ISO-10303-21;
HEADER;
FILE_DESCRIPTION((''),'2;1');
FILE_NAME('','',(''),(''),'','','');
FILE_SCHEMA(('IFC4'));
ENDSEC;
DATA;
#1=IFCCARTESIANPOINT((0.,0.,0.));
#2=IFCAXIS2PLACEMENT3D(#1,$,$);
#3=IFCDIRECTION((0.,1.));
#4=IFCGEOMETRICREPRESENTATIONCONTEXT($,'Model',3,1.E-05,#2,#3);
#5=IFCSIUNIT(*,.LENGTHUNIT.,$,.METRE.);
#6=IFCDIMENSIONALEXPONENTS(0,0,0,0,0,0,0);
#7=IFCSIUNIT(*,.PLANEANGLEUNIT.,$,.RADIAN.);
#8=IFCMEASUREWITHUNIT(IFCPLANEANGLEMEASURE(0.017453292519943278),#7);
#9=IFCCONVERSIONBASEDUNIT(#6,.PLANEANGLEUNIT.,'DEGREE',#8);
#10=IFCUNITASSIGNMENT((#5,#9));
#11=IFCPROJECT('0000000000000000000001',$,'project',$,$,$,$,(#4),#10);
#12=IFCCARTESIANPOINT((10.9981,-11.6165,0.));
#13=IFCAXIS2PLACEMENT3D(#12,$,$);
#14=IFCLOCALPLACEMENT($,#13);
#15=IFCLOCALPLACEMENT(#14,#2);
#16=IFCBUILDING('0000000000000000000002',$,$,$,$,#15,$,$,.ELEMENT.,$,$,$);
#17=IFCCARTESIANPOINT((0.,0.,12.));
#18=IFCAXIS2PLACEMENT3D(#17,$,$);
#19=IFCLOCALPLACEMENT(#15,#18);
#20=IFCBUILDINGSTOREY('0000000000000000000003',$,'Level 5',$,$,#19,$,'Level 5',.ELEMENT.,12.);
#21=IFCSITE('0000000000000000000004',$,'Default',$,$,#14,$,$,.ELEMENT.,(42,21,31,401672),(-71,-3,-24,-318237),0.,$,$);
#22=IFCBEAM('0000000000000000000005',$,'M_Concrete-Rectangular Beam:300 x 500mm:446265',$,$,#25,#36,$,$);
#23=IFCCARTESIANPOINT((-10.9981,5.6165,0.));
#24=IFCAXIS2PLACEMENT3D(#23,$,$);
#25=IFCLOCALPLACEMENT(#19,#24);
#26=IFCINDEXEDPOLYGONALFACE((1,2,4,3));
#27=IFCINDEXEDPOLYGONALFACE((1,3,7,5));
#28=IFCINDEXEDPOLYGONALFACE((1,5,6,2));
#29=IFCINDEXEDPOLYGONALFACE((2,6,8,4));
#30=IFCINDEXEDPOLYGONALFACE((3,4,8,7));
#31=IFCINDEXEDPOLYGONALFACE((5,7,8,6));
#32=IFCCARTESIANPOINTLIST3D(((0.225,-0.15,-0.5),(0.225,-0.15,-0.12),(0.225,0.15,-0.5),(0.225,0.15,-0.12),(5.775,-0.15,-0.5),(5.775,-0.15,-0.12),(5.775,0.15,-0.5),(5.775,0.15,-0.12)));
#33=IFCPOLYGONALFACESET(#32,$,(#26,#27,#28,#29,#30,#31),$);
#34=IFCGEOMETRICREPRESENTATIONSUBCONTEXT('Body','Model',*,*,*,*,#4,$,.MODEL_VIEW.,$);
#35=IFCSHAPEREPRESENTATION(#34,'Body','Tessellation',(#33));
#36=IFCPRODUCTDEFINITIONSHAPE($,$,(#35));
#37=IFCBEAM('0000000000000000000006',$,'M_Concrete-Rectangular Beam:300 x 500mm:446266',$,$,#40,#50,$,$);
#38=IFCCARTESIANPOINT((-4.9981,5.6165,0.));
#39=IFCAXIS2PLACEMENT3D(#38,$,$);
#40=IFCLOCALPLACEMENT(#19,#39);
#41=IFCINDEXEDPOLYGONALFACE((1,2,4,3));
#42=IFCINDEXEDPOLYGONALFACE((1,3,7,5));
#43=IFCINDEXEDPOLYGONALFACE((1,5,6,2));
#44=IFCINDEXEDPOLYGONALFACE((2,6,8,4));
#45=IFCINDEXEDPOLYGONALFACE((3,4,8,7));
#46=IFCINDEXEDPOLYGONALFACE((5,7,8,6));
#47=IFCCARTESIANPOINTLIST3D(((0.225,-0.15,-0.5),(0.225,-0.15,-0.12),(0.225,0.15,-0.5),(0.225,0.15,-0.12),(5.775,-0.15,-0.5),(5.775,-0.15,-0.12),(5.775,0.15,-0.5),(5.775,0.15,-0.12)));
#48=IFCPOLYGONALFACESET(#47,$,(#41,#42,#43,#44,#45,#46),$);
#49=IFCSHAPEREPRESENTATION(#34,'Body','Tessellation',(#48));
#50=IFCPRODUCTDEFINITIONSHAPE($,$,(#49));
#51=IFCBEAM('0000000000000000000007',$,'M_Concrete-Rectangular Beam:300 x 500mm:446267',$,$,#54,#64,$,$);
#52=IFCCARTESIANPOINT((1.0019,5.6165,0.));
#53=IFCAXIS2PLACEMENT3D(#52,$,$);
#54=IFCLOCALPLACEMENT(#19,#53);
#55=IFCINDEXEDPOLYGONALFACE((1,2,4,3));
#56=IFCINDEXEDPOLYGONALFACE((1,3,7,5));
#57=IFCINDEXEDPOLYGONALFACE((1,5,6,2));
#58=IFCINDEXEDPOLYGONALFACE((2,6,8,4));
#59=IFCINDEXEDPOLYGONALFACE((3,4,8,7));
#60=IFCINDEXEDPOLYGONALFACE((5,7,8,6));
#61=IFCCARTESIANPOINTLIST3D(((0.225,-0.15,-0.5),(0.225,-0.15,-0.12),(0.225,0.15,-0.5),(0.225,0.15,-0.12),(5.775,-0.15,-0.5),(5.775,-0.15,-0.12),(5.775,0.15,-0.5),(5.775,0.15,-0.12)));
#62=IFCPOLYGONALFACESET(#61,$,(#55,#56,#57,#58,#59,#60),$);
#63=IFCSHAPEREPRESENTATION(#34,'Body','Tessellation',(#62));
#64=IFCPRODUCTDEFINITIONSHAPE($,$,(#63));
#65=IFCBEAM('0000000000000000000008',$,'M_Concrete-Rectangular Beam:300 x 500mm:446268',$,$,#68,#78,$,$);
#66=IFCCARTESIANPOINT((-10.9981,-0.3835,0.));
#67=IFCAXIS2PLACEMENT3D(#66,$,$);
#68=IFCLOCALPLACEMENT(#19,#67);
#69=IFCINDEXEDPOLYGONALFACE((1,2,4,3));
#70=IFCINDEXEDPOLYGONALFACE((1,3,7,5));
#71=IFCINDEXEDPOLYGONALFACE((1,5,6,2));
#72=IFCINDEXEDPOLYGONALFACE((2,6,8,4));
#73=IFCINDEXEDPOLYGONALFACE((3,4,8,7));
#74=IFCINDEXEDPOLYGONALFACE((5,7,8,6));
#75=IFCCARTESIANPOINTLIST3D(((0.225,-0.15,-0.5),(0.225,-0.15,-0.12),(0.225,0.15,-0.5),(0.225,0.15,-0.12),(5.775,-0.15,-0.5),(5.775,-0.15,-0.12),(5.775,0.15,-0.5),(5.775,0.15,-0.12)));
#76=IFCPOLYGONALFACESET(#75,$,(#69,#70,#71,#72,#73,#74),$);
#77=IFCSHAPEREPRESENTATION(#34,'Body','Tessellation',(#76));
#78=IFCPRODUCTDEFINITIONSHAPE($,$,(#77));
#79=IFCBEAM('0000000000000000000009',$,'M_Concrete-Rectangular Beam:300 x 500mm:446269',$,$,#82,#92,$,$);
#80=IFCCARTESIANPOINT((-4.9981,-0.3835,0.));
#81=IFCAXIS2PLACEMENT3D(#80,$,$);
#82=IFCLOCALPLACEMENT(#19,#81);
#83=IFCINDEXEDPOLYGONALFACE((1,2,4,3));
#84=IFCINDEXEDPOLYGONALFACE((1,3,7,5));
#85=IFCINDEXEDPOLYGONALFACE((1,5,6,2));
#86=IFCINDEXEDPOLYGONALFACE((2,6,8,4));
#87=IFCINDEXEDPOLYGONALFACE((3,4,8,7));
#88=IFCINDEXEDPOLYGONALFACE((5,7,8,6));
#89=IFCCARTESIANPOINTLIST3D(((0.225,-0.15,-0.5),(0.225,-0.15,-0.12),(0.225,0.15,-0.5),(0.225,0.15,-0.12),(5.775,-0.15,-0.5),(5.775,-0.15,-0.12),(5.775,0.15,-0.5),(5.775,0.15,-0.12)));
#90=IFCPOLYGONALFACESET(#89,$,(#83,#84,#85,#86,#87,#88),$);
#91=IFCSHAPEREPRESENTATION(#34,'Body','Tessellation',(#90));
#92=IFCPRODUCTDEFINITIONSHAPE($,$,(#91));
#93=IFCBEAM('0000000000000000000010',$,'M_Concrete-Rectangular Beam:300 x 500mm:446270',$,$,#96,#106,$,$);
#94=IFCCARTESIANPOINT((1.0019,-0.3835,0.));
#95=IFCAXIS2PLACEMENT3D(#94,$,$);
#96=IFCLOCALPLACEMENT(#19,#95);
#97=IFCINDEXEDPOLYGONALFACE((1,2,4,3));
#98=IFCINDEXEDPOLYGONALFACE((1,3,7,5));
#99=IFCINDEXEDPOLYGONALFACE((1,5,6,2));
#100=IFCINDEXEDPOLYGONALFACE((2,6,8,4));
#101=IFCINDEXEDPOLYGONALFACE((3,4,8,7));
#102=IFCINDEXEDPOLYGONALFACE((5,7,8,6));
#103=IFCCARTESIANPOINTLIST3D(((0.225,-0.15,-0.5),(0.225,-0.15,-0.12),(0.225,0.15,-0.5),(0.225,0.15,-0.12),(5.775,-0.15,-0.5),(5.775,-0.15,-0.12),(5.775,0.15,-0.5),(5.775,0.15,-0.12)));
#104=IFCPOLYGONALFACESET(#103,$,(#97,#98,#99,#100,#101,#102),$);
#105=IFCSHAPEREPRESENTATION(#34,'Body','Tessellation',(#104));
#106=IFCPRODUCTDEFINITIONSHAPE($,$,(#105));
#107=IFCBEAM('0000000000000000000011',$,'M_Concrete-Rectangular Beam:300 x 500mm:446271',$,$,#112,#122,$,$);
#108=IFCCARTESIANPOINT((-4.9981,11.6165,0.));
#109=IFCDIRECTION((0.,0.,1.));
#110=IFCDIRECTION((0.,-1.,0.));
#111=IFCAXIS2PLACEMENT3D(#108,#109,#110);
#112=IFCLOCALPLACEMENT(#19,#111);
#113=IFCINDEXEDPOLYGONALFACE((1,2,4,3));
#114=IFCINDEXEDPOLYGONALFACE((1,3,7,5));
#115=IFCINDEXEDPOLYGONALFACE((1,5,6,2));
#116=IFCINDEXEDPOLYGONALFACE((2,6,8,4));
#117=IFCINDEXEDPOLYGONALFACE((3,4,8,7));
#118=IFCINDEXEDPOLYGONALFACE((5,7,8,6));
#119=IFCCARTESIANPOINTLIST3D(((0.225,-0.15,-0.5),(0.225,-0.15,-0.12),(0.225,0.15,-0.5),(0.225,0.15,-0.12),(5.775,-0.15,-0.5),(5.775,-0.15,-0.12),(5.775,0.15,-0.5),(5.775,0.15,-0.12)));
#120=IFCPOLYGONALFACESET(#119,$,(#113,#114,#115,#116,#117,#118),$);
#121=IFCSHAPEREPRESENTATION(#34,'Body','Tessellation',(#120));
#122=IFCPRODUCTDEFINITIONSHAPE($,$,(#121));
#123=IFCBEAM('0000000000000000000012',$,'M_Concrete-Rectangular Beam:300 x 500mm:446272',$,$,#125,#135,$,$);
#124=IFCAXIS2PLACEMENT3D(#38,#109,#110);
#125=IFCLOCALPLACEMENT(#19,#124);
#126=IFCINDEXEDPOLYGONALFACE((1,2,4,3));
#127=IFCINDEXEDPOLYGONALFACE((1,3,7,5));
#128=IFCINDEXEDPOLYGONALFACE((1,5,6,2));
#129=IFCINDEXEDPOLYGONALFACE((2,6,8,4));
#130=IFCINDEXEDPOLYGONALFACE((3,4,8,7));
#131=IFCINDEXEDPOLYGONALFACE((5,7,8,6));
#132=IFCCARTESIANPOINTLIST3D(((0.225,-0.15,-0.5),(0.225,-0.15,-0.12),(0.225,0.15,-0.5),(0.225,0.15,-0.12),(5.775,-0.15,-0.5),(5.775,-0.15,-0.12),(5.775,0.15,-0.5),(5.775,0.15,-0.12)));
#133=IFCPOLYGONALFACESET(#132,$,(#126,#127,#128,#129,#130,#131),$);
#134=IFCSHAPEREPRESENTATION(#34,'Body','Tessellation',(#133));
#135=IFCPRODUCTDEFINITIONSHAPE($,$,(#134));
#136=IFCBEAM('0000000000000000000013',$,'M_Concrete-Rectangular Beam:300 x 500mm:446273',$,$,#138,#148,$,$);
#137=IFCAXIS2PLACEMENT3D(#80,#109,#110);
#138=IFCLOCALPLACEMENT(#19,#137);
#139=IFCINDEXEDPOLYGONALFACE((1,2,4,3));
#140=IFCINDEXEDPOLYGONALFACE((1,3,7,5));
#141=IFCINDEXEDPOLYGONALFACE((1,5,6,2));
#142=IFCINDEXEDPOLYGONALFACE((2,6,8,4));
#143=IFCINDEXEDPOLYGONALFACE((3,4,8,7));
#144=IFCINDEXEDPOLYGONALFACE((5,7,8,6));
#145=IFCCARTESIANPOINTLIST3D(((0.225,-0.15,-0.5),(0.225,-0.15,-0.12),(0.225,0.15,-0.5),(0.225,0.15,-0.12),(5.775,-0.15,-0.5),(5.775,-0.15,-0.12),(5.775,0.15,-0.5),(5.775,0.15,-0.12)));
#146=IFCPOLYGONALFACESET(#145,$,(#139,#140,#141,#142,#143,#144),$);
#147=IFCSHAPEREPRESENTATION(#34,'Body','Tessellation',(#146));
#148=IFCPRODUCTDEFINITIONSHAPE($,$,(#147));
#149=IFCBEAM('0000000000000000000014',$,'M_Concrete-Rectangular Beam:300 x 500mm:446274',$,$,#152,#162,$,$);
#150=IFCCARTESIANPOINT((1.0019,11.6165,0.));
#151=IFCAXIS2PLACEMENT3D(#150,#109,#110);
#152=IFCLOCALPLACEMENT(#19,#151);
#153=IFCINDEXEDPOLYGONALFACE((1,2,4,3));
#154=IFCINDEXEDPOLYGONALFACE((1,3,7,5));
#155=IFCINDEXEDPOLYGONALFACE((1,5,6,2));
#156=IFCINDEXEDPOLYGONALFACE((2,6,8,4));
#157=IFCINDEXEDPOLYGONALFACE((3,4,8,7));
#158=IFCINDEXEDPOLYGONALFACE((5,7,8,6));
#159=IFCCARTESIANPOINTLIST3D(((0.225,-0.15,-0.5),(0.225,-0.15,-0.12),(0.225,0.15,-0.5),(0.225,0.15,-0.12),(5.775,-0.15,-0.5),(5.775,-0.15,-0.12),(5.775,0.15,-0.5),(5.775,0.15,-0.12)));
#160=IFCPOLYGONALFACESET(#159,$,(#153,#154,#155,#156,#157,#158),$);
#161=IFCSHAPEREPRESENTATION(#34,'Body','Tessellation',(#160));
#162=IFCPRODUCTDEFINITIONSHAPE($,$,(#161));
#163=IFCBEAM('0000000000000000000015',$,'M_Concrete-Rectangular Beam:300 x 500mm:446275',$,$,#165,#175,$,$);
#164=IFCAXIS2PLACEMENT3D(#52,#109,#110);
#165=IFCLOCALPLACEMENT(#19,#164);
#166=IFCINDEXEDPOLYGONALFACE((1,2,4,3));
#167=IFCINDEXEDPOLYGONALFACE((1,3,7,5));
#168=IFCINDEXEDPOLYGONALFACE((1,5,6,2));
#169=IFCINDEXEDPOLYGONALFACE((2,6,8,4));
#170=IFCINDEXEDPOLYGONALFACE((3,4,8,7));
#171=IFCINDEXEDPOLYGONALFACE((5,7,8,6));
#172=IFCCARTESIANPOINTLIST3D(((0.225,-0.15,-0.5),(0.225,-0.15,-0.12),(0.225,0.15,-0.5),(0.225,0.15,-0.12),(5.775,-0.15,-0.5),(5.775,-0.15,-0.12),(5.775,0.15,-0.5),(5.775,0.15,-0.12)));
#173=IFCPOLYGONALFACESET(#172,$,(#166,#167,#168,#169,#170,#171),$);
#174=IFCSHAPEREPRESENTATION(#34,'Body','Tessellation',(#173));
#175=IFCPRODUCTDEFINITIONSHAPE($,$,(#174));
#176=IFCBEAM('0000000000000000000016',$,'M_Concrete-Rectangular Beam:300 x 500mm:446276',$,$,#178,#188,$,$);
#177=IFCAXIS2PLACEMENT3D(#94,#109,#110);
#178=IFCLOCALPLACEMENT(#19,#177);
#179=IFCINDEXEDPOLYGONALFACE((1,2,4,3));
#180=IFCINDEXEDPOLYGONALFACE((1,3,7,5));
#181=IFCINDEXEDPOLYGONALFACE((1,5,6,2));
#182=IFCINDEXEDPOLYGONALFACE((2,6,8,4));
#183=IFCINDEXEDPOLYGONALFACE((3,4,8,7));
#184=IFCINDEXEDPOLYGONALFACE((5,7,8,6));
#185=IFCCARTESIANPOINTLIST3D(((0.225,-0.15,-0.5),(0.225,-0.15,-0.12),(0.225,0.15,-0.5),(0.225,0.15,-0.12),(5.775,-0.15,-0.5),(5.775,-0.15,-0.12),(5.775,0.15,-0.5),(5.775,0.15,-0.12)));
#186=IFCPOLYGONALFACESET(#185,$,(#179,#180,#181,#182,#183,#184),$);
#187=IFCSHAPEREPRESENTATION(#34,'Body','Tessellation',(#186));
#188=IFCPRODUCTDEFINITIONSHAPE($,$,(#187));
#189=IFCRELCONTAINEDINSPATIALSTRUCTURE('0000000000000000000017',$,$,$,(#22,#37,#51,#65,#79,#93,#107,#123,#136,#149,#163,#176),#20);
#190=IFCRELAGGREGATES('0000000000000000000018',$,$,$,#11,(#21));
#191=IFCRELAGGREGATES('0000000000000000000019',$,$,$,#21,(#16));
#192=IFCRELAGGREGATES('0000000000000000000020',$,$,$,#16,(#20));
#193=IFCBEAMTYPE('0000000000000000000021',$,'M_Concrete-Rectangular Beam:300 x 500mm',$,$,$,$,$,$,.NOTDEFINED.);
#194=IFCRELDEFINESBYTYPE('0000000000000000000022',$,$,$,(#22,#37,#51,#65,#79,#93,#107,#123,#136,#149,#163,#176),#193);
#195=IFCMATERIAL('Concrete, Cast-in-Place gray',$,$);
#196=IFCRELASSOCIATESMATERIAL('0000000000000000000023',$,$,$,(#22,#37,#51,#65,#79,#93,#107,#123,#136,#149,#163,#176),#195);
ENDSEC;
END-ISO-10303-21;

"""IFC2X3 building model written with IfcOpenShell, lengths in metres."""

from ifc_helpers import new_model, entity, si_unit, converted_unit, direction, frame, frame_2d, origin, place, context, subcontext, project, spatial, rectangle, extrude, material, type_object, element, save


model = new_model("IFC2X3")

# Units and contexts
model_context = context("Model", 3, precision=1e-05, world=origin(), true_north=direction((0.0, 1.0)))
body_context = subcontext(model_context, "Body", "Model", "MODEL_VIEW")
ifc_project = project(units=[si_unit("LENGTHUNIT", "METRE"), converted_unit("PLANEANGLEUNIT", "DEGREE", entity("IfcPlaneAngleMeasure", 0.017453292519943278), si_unit("PLANEANGLEUNIT", "RADIAN"), dimensions=[0, 0, 0, 0, 0, 0, 0])], contexts=[model_context])

# Site, building, storey
site_placement = place(None, frame((10.9981, -11.6165, 0.0)))
site = spatial("IfcSite", under=ifc_project, at=site_placement, Name="Default", CompositionType="ELEMENT", RefLatitude=(42, 21, 31, 401672), RefLongitude=(-71, -3, -24, -318237), RefElevation=0.0)
building_placement = place(site_placement, origin())
building = spatial("IfcBuilding", under=site, at=building_placement, CompositionType="ELEMENT")
storey_placement = place(building_placement, frame((0.0, 0.0, 12.0)))
storey = spatial("IfcBuildingStorey", under=building, at=storey_placement, Name="Level 5", LongName="Level 5", CompositionType="ELEMENT", Elevation=12.0)

# Beams
ifc_material_1 = material(Name="Concrete, Cast-in-Place gray")
beam_type = type_object("IfcBeamType", Name="M_Concrete-Rectangular Beam:300 x 500mm", PredefinedType="NOTDEFINED")
beam_1_placement = place(storey_placement, frame((-10.9981, 5.6165, 0.0)))
element("IfcBeam", 1, at=beam_1_placement, inside=storey, type_object=beam_type, material=ifc_material_1, Name="M_Concrete-Rectangular Beam:300 x 500mm:446265", context=body_context, shape_type="SweptSolid", body=[
    extrude(rectangle(XDim=0.38, YDim=0.3, at=frame_2d((0.0, 0.0), x_axis=(1.0, 0.0))), frame((0.225, 0.0, -0.31), z_axis=(1.0, 0.0, 0.0), x_axis=(0.0, 0.0, -1.0)), (0.0, 0.0, 1.0), 5.55),
])
beam_2_placement = place(storey_placement, frame((-4.9981, 5.6165, 0.0)))
element("IfcBeam", 2, at=beam_2_placement, inside=storey, type_object=beam_type, material=ifc_material_1, Name="M_Concrete-Rectangular Beam:300 x 500mm:446266", context=body_context, shape_type="SweptSolid", body=[
    extrude(rectangle(XDim=0.38, YDim=0.3, at=frame_2d((0.0, 0.0), x_axis=(1.0, 0.0))), frame((0.225, 0.0, -0.31), z_axis=(1.0, 0.0, 0.0), x_axis=(0.0, 0.0, -1.0)), (0.0, 0.0, 1.0), 5.55),
])
beam_3_placement = place(storey_placement, frame((1.0019, 5.6165, 0.0)))
element("IfcBeam", 3, at=beam_3_placement, inside=storey, type_object=beam_type, material=ifc_material_1, Name="M_Concrete-Rectangular Beam:300 x 500mm:446267", context=body_context, shape_type="SweptSolid", body=[
    extrude(rectangle(XDim=0.38, YDim=0.3, at=frame_2d((0.0, 0.0), x_axis=(1.0, 0.0))), frame((0.225, 0.0, -0.31), z_axis=(1.0, 0.0, 0.0), x_axis=(0.0, 0.0, -1.0)), (0.0, 0.0, 1.0), 5.55),
])
beam_4_placement = place(storey_placement, frame((-10.9981, -0.3835, 0.0)))
element("IfcBeam", 4, at=beam_4_placement, inside=storey, type_object=beam_type, material=ifc_material_1, Name="M_Concrete-Rectangular Beam:300 x 500mm:446268", context=body_context, shape_type="SweptSolid", body=[
    extrude(rectangle(XDim=0.38, YDim=0.3, at=frame_2d((0.0, 0.0), x_axis=(1.0, 0.0))), frame((0.225, 0.0, -0.31), z_axis=(1.0, 0.0, 0.0), x_axis=(0.0, 0.0, -1.0)), (0.0, 0.0, 1.0), 5.55),
])
beam_5_placement = place(storey_placement, frame((-4.9981, -0.3835, 0.0)))
element("IfcBeam", 5, at=beam_5_placement, inside=storey, type_object=beam_type, material=ifc_material_1, Name="M_Concrete-Rectangular Beam:300 x 500mm:446269", context=body_context, shape_type="SweptSolid", body=[
    extrude(rectangle(XDim=0.38, YDim=0.3, at=frame_2d((0.0, 0.0), x_axis=(1.0, 0.0))), frame((0.225, 0.0, -0.31), z_axis=(1.0, 0.0, 0.0), x_axis=(0.0, 0.0, -1.0)), (0.0, 0.0, 1.0), 5.55),
])
beam_6_placement = place(storey_placement, frame((1.0019, -0.3835, 0.0)))
element("IfcBeam", 6, at=beam_6_placement, inside=storey, type_object=beam_type, material=ifc_material_1, Name="M_Concrete-Rectangular Beam:300 x 500mm:446270", context=body_context, shape_type="SweptSolid", body=[
    extrude(rectangle(XDim=0.38, YDim=0.3, at=frame_2d((0.0, 0.0), x_axis=(1.0, 0.0))), frame((0.225, 0.0, -0.31), z_axis=(1.0, 0.0, 0.0), x_axis=(0.0, 0.0, -1.0)), (0.0, 0.0, 1.0), 5.55),
])
beam_7_placement = place(storey_placement, frame((-4.9981, 11.6165, 0.0), z_axis=(0.0, 0.0, 1.0), x_axis=(0.0, -1.0, 0.0)))
element("IfcBeam", 7, at=beam_7_placement, inside=storey, type_object=beam_type, material=ifc_material_1, Name="M_Concrete-Rectangular Beam:300 x 500mm:446271", context=body_context, shape_type="SweptSolid", body=[
    extrude(rectangle(XDim=0.38, YDim=0.3, at=frame_2d((0.0, 0.0), x_axis=(1.0, 0.0))), frame((0.225, 0.0, -0.31), z_axis=(1.0, 0.0, 0.0), x_axis=(0.0, 0.0, -1.0)), (0.0, 0.0, 1.0), 5.55),
])
beam_8_placement = place(storey_placement, frame((-4.9981, 5.6165, 0.0), z_axis=(0.0, 0.0, 1.0), x_axis=(0.0, -1.0, 0.0)))
element("IfcBeam", 8, at=beam_8_placement, inside=storey, type_object=beam_type, material=ifc_material_1, Name="M_Concrete-Rectangular Beam:300 x 500mm:446272", context=body_context, shape_type="SweptSolid", body=[
    extrude(rectangle(XDim=0.38, YDim=0.3, at=frame_2d((0.0, 0.0), x_axis=(1.0, 0.0))), frame((0.225, 0.0, -0.31), z_axis=(1.0, 0.0, 0.0), x_axis=(0.0, 0.0, -1.0)), (0.0, 0.0, 1.0), 5.55),
])
beam_9_placement = place(storey_placement, frame((-4.9981, -0.3835, 0.0), z_axis=(0.0, 0.0, 1.0), x_axis=(0.0, -1.0, 0.0)))
element("IfcBeam", 9, at=beam_9_placement, inside=storey, type_object=beam_type, material=ifc_material_1, Name="M_Concrete-Rectangular Beam:300 x 500mm:446273", context=body_context, shape_type="SweptSolid", body=[
    extrude(rectangle(XDim=0.38, YDim=0.3, at=frame_2d((0.0, 0.0), x_axis=(1.0, 0.0))), frame((0.225, 0.0, -0.31), z_axis=(1.0, 0.0, 0.0), x_axis=(0.0, 0.0, -1.0)), (0.0, 0.0, 1.0), 5.55),
])
beam_10_placement = place(storey_placement, frame((1.0019, 11.6165, 0.0), z_axis=(0.0, 0.0, 1.0), x_axis=(0.0, -1.0, 0.0)))
element("IfcBeam", 10, at=beam_10_placement, inside=storey, type_object=beam_type, material=ifc_material_1, Name="M_Concrete-Rectangular Beam:300 x 500mm:446274", context=body_context, shape_type="SweptSolid", body=[
    extrude(rectangle(XDim=0.38, YDim=0.3, at=frame_2d((0.0, 0.0), x_axis=(1.0, 0.0))), frame((0.225, 0.0, -0.31), z_axis=(1.0, 0.0, 0.0), x_axis=(0.0, 0.0, -1.0)), (0.0, 0.0, 1.0), 5.55),
])
beam_11_placement = place(storey_placement, frame((1.0019, 5.6165, 0.0), z_axis=(0.0, 0.0, 1.0), x_axis=(0.0, -1.0, 0.0)))
element("IfcBeam", 11, at=beam_11_placement, inside=storey, type_object=beam_type, material=ifc_material_1, Name="M_Concrete-Rectangular Beam:300 x 500mm:446275", context=body_context, shape_type="SweptSolid", body=[
    extrude(rectangle(XDim=0.38, YDim=0.3, at=frame_2d((0.0, 0.0), x_axis=(1.0, 0.0))), frame((0.225, 0.0, -0.31), z_axis=(1.0, 0.0, 0.0), x_axis=(0.0, 0.0, -1.0)), (0.0, 0.0, 1.0), 5.55),
])
beam_12_placement = place(storey_placement, frame((1.0019, -0.3835, 0.0), z_axis=(0.0, 0.0, 1.0), x_axis=(0.0, -1.0, 0.0)))
element("IfcBeam", 12, at=beam_12_placement, inside=storey, type_object=beam_type, material=ifc_material_1, Name="M_Concrete-Rectangular Beam:300 x 500mm:446276", context=body_context, shape_type="SweptSolid", body=[
    extrude(rectangle(XDim=0.38, YDim=0.3, at=frame_2d((0.0, 0.0), x_axis=(1.0, 0.0))), frame((0.225, 0.0, -0.31), z_axis=(1.0, 0.0, 0.0), x_axis=(0.0, 0.0, -1.0)), (0.0, 0.0, 1.0), 5.55),
])

save(model, "model.ifc")
